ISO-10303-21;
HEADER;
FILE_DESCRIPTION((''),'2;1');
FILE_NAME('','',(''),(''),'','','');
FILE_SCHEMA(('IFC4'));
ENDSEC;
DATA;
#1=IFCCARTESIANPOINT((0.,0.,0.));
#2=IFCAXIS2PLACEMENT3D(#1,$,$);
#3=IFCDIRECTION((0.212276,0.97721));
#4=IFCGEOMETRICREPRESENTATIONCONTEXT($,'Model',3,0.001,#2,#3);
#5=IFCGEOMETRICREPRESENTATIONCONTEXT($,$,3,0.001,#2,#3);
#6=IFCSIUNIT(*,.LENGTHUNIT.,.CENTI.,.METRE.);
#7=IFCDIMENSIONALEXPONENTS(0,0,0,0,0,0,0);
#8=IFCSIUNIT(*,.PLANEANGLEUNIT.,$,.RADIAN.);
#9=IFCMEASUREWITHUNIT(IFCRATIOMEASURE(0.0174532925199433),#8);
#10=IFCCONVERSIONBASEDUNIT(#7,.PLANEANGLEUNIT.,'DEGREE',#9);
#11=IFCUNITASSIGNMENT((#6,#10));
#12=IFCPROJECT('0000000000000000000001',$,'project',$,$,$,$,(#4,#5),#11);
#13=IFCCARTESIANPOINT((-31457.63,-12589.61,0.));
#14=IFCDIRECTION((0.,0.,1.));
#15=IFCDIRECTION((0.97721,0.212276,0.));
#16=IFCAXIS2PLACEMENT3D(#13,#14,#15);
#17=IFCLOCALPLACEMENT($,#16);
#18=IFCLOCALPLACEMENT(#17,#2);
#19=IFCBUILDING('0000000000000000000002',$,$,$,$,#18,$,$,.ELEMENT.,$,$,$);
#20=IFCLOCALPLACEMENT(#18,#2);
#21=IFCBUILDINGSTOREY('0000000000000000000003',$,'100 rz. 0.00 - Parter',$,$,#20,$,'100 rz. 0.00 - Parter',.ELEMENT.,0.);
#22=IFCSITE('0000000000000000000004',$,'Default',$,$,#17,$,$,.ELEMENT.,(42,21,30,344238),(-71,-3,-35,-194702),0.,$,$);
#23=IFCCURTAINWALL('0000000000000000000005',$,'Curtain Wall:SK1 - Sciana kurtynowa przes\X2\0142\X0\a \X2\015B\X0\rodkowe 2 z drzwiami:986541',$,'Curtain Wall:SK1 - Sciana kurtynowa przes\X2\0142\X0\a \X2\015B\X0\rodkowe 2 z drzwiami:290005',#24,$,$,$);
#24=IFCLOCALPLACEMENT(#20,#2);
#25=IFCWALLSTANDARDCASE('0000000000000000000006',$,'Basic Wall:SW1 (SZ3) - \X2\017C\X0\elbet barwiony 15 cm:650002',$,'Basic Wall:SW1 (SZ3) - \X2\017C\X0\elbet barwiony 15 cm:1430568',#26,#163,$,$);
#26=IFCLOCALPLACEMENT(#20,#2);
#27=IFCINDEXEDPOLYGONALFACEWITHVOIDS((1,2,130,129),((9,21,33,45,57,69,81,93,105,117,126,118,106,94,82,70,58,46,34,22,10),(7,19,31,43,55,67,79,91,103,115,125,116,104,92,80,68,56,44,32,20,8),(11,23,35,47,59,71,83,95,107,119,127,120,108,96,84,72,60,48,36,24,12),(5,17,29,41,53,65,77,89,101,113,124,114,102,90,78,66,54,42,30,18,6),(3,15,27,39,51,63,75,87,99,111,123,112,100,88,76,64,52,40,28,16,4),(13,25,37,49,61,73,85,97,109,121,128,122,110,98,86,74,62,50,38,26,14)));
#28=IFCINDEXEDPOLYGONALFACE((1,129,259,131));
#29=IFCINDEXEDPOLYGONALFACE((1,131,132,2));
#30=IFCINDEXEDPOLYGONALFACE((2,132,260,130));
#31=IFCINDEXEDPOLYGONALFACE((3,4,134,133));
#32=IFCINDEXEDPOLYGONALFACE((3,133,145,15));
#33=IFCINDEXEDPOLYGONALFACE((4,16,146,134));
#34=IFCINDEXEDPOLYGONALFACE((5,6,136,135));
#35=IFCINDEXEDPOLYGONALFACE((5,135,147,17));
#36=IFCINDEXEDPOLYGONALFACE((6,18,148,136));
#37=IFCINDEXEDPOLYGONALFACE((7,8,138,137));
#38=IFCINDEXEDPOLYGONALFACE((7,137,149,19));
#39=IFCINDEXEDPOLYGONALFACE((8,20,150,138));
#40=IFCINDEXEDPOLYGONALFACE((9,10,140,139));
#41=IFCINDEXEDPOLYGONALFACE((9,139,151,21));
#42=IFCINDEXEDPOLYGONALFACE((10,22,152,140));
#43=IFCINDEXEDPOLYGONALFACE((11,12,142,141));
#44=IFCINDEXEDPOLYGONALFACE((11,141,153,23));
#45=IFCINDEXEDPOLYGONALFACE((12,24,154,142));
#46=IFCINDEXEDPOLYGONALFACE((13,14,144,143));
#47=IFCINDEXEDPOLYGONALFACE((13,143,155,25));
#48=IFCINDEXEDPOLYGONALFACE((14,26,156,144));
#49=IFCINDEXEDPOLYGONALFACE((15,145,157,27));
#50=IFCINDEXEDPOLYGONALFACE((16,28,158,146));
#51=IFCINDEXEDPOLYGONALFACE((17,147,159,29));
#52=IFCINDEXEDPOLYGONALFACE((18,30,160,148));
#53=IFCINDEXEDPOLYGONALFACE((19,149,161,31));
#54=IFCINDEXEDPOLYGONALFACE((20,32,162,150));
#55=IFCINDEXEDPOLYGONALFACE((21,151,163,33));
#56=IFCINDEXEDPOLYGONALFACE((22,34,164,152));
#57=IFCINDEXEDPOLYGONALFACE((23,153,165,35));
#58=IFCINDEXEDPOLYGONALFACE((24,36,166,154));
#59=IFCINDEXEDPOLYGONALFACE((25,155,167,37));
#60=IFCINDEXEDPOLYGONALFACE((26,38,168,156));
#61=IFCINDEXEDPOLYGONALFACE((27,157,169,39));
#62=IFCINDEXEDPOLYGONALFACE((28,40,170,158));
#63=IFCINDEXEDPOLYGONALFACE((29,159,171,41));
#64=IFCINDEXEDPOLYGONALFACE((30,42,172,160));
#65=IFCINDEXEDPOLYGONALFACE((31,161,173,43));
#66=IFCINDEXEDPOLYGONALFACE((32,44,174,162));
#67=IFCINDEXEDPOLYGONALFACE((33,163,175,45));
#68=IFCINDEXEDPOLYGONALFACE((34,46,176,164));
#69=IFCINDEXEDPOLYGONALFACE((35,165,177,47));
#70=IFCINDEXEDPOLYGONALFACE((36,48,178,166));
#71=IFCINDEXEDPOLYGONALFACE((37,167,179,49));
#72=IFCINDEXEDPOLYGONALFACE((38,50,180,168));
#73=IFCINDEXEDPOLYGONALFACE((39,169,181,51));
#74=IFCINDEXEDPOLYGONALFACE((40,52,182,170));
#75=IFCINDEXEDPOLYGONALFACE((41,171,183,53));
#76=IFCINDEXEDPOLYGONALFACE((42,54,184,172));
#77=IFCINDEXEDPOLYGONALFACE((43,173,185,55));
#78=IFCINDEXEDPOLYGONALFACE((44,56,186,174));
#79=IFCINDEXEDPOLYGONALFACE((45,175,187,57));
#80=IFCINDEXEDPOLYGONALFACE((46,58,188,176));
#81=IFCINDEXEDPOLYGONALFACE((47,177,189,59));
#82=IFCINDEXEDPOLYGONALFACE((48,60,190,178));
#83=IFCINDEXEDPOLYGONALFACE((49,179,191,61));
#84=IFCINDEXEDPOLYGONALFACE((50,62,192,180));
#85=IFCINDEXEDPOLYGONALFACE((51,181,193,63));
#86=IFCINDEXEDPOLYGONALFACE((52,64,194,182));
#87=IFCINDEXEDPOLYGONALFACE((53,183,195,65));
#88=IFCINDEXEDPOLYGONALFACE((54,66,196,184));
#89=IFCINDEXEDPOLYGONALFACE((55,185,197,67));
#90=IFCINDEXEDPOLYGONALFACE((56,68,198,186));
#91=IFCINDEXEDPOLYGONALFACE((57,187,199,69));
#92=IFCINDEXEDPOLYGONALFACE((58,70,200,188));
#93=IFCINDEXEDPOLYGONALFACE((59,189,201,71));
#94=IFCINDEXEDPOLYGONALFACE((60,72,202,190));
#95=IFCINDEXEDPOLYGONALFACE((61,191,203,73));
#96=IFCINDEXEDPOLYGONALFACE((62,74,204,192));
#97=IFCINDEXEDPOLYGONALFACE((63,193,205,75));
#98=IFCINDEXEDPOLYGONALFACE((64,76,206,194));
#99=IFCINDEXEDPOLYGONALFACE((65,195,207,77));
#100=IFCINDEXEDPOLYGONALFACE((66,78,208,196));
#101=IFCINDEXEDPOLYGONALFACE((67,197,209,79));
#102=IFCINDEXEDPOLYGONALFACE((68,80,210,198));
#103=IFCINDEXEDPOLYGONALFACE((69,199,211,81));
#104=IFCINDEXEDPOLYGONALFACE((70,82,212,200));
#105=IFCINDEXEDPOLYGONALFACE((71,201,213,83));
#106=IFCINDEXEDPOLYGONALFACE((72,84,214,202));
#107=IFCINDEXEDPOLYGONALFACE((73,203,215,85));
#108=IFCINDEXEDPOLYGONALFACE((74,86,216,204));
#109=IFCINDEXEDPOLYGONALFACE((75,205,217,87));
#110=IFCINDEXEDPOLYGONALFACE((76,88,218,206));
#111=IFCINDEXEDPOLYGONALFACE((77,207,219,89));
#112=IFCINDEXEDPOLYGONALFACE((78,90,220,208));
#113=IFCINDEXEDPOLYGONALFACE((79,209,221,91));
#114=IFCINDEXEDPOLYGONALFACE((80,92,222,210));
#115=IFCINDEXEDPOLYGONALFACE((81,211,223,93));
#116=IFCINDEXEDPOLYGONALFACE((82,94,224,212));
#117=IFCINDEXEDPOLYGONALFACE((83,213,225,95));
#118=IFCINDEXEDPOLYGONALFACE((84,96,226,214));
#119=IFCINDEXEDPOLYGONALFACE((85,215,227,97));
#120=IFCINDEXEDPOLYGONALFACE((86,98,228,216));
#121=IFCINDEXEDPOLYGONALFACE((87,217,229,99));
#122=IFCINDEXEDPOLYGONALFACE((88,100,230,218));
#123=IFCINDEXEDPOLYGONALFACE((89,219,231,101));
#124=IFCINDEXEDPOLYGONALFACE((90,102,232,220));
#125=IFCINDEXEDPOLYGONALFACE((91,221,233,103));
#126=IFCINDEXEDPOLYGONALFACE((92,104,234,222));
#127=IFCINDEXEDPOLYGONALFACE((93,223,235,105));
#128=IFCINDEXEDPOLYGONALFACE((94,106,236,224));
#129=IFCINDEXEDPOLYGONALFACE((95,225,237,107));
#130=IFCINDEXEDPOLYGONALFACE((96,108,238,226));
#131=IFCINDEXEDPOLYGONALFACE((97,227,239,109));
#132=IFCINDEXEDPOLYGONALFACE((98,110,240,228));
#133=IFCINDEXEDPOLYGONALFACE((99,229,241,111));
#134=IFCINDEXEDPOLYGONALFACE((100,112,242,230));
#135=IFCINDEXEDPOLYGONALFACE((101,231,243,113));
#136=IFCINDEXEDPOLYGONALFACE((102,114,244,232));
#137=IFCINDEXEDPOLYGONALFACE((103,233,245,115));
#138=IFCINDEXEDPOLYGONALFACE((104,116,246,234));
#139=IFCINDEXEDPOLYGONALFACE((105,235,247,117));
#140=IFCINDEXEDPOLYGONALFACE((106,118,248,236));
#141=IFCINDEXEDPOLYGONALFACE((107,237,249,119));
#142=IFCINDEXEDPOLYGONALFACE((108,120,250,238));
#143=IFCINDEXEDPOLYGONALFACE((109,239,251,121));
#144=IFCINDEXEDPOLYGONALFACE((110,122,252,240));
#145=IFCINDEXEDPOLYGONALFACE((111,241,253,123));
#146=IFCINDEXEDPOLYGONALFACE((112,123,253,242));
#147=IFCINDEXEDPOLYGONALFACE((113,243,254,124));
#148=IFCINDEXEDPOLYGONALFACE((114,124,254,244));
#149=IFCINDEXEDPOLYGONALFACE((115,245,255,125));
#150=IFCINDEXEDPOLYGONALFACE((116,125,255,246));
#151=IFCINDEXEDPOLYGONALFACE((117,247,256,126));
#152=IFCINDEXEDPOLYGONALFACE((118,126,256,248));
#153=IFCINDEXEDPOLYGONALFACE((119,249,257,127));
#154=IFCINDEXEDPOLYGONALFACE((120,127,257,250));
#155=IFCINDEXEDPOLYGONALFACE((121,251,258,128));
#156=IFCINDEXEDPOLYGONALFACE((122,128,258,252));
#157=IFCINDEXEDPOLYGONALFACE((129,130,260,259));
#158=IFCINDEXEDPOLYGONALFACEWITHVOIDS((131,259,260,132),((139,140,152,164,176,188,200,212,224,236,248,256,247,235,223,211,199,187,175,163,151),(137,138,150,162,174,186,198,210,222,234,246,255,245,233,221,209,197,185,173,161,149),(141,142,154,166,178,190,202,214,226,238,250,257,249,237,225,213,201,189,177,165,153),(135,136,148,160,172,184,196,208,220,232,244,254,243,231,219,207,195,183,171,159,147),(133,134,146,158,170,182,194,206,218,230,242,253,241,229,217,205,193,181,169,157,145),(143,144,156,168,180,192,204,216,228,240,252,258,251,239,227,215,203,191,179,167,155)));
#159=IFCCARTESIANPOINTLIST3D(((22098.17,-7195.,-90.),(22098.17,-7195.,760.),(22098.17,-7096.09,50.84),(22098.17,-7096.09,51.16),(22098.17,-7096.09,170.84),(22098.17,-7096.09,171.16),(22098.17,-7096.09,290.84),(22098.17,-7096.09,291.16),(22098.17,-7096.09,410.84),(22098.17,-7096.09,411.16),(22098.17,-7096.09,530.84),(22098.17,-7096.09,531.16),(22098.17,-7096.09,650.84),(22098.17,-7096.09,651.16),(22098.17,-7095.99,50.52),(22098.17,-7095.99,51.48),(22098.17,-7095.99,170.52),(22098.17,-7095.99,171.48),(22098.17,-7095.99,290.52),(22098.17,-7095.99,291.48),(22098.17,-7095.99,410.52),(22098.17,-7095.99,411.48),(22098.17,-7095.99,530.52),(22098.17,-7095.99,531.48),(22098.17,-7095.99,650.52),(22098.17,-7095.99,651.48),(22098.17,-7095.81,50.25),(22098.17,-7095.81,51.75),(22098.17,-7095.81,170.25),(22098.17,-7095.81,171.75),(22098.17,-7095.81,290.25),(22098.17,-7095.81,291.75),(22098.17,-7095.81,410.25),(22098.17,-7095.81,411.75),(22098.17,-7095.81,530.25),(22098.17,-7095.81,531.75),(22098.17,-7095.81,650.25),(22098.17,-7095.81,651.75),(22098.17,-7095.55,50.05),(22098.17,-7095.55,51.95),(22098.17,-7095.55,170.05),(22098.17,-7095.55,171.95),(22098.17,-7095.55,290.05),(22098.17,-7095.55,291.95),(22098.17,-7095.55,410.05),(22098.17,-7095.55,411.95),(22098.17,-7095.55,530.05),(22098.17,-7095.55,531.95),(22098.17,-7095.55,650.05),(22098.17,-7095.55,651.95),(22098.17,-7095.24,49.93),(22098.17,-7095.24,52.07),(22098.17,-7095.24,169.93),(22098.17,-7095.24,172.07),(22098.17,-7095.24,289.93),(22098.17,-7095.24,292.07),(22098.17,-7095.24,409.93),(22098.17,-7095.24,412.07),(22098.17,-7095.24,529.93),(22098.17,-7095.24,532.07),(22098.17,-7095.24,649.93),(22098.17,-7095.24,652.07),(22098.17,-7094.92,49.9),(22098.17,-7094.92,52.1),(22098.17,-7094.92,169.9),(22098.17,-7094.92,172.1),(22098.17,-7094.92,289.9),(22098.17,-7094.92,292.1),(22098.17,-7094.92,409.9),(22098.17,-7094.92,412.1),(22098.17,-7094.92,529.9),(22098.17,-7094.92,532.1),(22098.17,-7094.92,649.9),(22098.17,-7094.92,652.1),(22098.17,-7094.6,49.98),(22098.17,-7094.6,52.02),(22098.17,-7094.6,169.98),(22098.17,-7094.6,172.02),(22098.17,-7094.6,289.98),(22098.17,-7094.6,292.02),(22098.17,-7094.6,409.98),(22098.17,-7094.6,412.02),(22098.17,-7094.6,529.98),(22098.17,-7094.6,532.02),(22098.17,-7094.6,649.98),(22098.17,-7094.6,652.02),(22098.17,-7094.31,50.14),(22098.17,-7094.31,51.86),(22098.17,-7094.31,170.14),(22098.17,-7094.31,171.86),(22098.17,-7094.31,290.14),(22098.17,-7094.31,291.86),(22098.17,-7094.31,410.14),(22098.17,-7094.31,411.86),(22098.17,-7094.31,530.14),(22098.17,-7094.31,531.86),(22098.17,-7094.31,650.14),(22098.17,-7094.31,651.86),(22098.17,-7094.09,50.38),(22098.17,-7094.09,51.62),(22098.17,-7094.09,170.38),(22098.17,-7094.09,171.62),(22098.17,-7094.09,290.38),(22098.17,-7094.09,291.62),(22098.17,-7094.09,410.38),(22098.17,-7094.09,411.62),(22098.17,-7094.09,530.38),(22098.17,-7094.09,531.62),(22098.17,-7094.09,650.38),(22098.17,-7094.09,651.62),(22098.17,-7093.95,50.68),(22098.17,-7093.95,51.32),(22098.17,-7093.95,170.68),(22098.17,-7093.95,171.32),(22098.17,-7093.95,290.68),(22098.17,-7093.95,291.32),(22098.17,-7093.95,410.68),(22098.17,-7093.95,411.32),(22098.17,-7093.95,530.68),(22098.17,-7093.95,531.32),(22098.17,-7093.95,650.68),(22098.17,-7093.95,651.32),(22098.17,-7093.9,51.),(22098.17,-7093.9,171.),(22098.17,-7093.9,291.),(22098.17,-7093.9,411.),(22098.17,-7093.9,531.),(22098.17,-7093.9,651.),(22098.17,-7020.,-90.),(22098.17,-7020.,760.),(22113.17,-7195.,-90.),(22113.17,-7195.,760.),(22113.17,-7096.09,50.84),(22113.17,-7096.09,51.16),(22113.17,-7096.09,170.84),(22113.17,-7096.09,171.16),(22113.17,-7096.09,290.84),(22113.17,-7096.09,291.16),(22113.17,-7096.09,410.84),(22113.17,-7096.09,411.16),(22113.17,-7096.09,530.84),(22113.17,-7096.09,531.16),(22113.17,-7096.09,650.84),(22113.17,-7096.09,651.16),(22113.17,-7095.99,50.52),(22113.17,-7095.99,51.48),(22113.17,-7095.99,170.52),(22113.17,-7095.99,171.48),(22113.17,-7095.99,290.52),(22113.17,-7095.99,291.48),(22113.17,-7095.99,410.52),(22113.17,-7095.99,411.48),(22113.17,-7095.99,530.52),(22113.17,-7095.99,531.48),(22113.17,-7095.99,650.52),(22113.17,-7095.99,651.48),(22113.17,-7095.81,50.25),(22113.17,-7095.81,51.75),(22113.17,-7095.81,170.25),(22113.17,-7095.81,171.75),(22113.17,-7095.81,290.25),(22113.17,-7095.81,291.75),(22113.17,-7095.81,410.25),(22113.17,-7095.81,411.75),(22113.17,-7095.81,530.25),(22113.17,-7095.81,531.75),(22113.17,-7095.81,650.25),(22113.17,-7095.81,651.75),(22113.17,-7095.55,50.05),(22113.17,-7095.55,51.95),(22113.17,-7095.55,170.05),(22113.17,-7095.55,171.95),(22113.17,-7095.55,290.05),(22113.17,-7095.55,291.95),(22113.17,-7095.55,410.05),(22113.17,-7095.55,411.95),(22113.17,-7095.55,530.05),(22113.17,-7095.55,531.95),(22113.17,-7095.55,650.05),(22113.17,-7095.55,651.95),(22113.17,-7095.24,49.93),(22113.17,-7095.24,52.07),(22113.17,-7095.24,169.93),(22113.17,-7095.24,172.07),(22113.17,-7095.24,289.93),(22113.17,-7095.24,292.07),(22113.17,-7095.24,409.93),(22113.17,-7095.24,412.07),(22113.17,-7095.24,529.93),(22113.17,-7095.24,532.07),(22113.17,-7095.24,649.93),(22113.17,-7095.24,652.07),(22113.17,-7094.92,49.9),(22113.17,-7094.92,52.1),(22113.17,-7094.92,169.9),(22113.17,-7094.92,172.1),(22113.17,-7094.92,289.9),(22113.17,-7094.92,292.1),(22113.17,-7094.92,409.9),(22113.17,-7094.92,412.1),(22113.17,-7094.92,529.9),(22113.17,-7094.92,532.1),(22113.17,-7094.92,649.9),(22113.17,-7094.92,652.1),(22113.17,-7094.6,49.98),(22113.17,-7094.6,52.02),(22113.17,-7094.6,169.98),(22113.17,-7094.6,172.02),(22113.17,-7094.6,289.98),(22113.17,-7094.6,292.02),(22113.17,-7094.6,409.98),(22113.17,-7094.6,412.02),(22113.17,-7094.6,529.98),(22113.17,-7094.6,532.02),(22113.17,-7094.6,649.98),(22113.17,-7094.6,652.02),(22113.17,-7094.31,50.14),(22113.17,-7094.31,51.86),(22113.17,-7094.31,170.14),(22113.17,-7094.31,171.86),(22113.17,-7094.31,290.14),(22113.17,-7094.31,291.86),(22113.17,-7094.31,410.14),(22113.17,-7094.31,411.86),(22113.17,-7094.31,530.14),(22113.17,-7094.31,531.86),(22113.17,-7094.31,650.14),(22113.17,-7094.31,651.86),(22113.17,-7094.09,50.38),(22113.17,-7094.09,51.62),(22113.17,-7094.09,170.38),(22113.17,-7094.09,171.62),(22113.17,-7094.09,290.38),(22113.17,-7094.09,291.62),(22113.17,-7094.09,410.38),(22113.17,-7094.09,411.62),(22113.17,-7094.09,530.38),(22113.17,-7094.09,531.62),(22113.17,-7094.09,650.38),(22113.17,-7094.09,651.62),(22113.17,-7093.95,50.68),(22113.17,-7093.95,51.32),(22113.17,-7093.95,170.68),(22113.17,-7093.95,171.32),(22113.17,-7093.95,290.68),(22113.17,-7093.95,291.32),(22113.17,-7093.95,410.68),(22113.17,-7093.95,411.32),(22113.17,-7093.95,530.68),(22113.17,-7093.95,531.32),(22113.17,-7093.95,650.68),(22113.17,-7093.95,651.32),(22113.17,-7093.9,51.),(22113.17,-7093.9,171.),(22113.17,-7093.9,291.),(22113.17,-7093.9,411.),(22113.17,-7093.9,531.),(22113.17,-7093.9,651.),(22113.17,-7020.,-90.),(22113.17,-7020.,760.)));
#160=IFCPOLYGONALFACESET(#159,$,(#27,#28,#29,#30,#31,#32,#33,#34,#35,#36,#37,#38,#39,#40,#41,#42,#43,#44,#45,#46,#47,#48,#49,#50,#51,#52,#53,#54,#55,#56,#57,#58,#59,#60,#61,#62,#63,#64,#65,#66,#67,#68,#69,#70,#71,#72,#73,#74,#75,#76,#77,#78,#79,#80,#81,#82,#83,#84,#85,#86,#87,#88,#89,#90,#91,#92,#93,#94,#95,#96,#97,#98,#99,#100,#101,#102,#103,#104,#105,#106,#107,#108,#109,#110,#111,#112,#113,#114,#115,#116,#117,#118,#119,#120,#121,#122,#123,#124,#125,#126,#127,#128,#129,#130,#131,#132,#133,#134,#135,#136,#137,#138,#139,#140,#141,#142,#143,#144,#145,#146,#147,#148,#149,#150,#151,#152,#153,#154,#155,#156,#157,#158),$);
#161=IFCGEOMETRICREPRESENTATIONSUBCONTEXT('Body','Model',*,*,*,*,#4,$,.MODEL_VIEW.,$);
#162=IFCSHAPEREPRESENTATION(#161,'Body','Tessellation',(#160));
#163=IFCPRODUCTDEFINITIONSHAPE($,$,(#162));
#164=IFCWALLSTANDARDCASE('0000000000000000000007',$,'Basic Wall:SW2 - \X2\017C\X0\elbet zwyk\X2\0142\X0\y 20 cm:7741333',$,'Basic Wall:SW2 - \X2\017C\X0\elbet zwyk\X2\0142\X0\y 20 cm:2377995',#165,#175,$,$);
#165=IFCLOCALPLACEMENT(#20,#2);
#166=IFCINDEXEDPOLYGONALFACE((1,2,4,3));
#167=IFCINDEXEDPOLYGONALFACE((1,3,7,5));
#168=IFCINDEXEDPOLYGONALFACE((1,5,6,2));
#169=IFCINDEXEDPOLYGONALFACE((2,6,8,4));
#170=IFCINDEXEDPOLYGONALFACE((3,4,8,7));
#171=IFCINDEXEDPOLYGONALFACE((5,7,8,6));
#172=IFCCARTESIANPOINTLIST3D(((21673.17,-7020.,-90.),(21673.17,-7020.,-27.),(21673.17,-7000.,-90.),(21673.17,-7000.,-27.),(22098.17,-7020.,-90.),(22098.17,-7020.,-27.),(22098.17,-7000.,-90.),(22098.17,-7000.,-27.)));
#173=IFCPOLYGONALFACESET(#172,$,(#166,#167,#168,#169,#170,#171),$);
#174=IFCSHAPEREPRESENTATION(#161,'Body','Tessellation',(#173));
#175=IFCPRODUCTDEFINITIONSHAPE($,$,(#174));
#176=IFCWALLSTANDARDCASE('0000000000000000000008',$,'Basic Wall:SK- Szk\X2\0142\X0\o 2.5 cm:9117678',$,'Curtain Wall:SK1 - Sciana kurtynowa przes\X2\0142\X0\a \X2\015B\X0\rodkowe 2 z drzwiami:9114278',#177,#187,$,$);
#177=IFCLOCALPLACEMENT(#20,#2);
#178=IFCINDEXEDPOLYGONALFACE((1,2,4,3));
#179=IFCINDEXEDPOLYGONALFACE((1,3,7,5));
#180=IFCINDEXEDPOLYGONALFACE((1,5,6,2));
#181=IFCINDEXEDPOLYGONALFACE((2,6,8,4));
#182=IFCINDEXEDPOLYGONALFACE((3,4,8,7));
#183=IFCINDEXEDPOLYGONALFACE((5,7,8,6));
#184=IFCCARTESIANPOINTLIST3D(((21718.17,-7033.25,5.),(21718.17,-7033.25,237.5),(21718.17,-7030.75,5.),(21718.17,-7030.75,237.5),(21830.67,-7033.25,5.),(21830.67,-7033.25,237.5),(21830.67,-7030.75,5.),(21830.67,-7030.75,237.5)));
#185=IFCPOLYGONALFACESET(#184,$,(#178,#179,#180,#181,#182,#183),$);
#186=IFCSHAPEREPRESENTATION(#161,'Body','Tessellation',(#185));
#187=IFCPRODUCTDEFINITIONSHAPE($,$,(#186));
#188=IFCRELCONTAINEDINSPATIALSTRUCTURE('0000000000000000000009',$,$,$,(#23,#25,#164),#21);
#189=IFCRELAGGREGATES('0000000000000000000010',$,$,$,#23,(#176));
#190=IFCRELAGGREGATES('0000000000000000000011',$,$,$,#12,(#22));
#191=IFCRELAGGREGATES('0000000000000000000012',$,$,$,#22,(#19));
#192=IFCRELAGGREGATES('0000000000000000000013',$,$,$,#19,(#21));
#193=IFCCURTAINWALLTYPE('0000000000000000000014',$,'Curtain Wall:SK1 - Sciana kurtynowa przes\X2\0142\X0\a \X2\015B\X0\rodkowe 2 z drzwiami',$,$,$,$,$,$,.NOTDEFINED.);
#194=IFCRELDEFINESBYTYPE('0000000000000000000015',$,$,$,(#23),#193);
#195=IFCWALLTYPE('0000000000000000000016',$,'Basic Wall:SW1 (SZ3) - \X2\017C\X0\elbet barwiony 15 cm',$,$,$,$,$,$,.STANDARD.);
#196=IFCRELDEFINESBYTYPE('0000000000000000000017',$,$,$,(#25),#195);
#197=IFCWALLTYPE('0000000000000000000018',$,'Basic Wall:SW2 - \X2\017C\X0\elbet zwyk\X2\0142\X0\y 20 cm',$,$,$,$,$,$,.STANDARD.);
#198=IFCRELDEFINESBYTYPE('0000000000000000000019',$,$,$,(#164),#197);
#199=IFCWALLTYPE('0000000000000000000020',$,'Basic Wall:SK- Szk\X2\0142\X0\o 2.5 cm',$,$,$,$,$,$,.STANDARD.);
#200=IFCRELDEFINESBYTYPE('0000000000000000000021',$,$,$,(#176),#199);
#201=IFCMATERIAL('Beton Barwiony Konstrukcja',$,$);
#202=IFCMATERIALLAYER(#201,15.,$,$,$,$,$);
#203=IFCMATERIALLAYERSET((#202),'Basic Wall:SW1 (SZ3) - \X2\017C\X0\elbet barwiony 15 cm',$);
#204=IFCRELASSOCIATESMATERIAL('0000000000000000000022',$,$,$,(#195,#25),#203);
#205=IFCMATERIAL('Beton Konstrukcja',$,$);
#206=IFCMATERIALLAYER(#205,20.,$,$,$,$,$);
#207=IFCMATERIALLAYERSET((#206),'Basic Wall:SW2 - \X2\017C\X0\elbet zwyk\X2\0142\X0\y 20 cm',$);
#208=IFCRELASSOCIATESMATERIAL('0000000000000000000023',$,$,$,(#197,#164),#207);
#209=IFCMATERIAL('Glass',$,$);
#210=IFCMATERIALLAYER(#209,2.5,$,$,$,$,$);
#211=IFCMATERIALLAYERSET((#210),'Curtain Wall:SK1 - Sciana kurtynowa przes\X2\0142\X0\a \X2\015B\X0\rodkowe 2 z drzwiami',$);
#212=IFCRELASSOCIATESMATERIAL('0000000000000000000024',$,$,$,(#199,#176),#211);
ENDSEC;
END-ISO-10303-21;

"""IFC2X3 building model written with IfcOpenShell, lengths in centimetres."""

from ifc_helpers import new_model, entity, si_unit, converted_unit, direction, frame, frame_2d, origin, origin_2d_with_axis, place, context, subcontext, project, spatial, rectangle, circle, extrude, material, layer, layer_set, layer_usage, type_object, element, aggregate, save


model = new_model("IFC2X3")

# Units and contexts
model_context = context("Model", 3, precision=0.001, world=origin(), true_north=direction((0.212276, 0.97721)))
context_of_model = context(None, 3, precision=0.001, world=origin(), true_north=direction((0.212276, 0.97721)))
body_context = subcontext(model_context, "Body", "Model", "MODEL_VIEW")
ifc_project = project(units=[si_unit("LENGTHUNIT", "METRE", prefix="CENTI"), converted_unit("PLANEANGLEUNIT", "DEGREE", entity("IfcRatioMeasure", 0.0174532925199433), si_unit("PLANEANGLEUNIT", "RADIAN"), dimensions=[0, 0, 0, 0, 0, 0, 0])], contexts=[model_context, context_of_model])

# Site, building, storey
site_placement = place(None, frame((-31457.63, -12589.61, 0.0), z_axis=(0.0, 0.0, 1.0), x_axis=(0.97721, 0.212276, 0.0)))
site = spatial("IfcSite", under=ifc_project, at=site_placement, Name="Default", CompositionType="ELEMENT", RefLatitude=(42, 21, 30, 344238), RefLongitude=(-71, -3, -35, -194702), RefElevation=0.0)
building_placement = place(site_placement, origin())
building = spatial("IfcBuilding", under=site, at=building_placement, CompositionType="ELEMENT")
storey_placement = place(building_placement, origin())
storey = spatial("IfcBuildingStorey", under=building, at=storey_placement, Name="100 rz. 0.00 - Parter", LongName="100 rz. 0.00 - Parter", CompositionType="ELEMENT", Elevation=0.0)

# Curtain wall
curtain_wall_type = type_object("IfcCurtainWallType", Name="Curtain Wall:SK1 - Sciana kurtynowa przesła środkowe 2 z drzwiami", PredefinedType="NOTDEFINED")
curtain_wall_placement = place(storey_placement, origin())
curtain_wall = element("IfcCurtainWall", 1, at=curtain_wall_placement, inside=storey, type_object=curtain_wall_type, Name="Curtain Wall:SK1 - Sciana kurtynowa przesła środkowe 2 z drzwiami:986541", ObjectType="Curtain Wall:SK1 - Sciana kurtynowa przesła środkowe 2 z drzwiami:290005")

# Wall, opening
ifc_material_1 = material(Name="Beton Barwiony Konstrukcja")
ifc_layer_1 = layer(ifc_material_1, 15.0)
ifc_layer_set_1 = layer_set([ifc_layer_1], Name="Basic Wall:SW1 (SZ3) - żelbet barwiony 15 cm")
ifc_layer_usage_1 = layer_usage(ifc_layer_set_1, "AXIS2", "NEGATIVE", 7.5)
wall_type_1 = type_object("IfcWallType", Name="Basic Wall:SW1 (SZ3) - żelbet barwiony 15 cm", PredefinedType="STANDARD", material=ifc_layer_set_1)
wall_1_placement = place(storey_placement, frame((22105.67, -7020.0, -90.0), z_axis=(0.0, 0.0, 1.0), x_axis=(0.0, -1.0, 0.0)))
wall_1 = element("IfcWallStandardCase", 2, at=wall_1_placement, inside=storey, type_object=wall_type_1, material=ifc_layer_usage_1, Name="Basic Wall:SW1 (SZ3) - żelbet barwiony 15 cm:650002", ObjectType="Basic Wall:SW1 (SZ3) - żelbet barwiony 15 cm:1430568", context=body_context, shape_type="SweptSolid", body=[
    extrude(rectangle(XDim=175.0, YDim=15.0, at=frame_2d((87.5, 0.0), x_axis=(-1.0, 0.0))), origin(), (0.0, 0.0, 1.0), 850.0),
])
opening_placement = place(wall_1_placement, frame((76.26, -7.5, 139.74)))
element("IfcOpeningElement", 3, at=opening_placement, cuts=wall_1, ObjectType="Opening", context=body_context, shape_type="SweptSolid", body=[
    extrude(circle(Radius=1.1, at=frame_2d((0.0, 0.0), x_axis=(1.0, 0.0))), frame((-1.26, 0.0, 1.26), z_axis=(0.0, 1.0, 0.0), x_axis=(-1.0, 0.0, 0.0)), (0.0, 0.0, 1.0), 15.0),
    extrude(circle(Radius=1.1, at=origin_2d_with_axis()), frame((-1.26, 0.0, 601.26), z_axis=(0.0, 1.0, 0.0), x_axis=(-1.0, 0.0, 0.0)), (0.0, 0.0, 1.0), 15.0),
    extrude(circle(Radius=1.1, at=origin_2d_with_axis()), frame((-1.26, 0.0, 121.26), z_axis=(0.0, 1.0, 0.0), x_axis=(-1.0, 0.0, 0.0)), (0.0, 0.0, 1.0), 15.0),
    extrude(circle(Radius=1.1, at=origin_2d_with_axis()), frame((-1.26, 0.0, 241.26), z_axis=(0.0, 1.0, 0.0), x_axis=(-1.0, 0.0, 0.0)), (0.0, 0.0, 1.0), 15.0),
    extrude(circle(Radius=1.1, at=origin_2d_with_axis()), frame((-1.26, 0.0, 361.26), z_axis=(0.0, 1.0, 0.0), x_axis=(-1.0, 0.0, 0.0)), (0.0, 0.0, 1.0), 15.0),
    extrude(circle(Radius=1.1, at=origin_2d_with_axis()), frame((-1.26, 0.0, 481.26), z_axis=(0.0, 1.0, 0.0), x_axis=(-1.0, 0.0, 0.0)), (0.0, 0.0, 1.0), 15.0),
])

# Walls
ifc_material_2 = material(Name="Beton Konstrukcja")
ifc_layer_2 = layer(ifc_material_2, 20.0)
ifc_layer_set_2 = layer_set([ifc_layer_2], Name="Basic Wall:SW2 - żelbet zwykły 20 cm")
ifc_layer_usage_2 = layer_usage(ifc_layer_set_2, "AXIS2", "NEGATIVE", 10.0)
wall_type_2 = type_object("IfcWallType", Name="Basic Wall:SW2 - żelbet zwykły 20 cm", PredefinedType="STANDARD", material=ifc_layer_set_2)
wall_2_placement = place(storey_placement, frame((21673.17, -7010.0, -90.0)))
element("IfcWallStandardCase", 4, at=wall_2_placement, inside=storey, type_object=wall_type_2, material=ifc_layer_usage_2, Name="Basic Wall:SW2 - żelbet zwykły 20 cm:7741333", ObjectType="Basic Wall:SW2 - żelbet zwykły 20 cm:2377995", context=body_context, shape_type="SweptSolid", body=[
    extrude(rectangle(XDim=425.0, YDim=20.0, at=frame_2d((212.5, 0.0), x_axis=(-1.0, 0.0))), origin(), (0.0, 0.0, 1.0), 63.0),
])
ifc_material_3 = material(Name="Glass")
ifc_layer_3 = layer(ifc_material_3, 2.5)
ifc_layer_set_3 = layer_set([ifc_layer_3], Name="Curtain Wall:SK1 - Sciana kurtynowa przesła środkowe 2 z drzwiami")
ifc_layer_usage_3 = layer_usage(ifc_layer_set_3, "AXIS2", "POSITIVE", -1.25)
wall_type_3 = type_object("IfcWallType", Name="Basic Wall:SK- Szkło 2.5 cm", PredefinedType="STANDARD", material=ifc_layer_set_3)
wall_3_placement = place(storey_placement, frame((21718.17, -7032.0, 5.0)))
wall_3 = element("IfcWallStandardCase", 5, at=wall_3_placement, type_object=wall_type_3, material=ifc_layer_usage_3, Name="Basic Wall:SK- Szkło 2.5 cm:9117678", ObjectType="Curtain Wall:SK1 - Sciana kurtynowa przesła środkowe 2 z drzwiami:9114278", context=body_context, shape_type="SweptSolid", body=[
    extrude(rectangle(XDim=112.5, YDim=2.5, at=frame_2d((56.25, 0.0), x_axis=(-1.0, 0.0))), origin(), (0.0, 0.0, 1.0), 232.5),
])
aggregate(curtain_wall, [wall_3])

save(model, "model.ifc")
